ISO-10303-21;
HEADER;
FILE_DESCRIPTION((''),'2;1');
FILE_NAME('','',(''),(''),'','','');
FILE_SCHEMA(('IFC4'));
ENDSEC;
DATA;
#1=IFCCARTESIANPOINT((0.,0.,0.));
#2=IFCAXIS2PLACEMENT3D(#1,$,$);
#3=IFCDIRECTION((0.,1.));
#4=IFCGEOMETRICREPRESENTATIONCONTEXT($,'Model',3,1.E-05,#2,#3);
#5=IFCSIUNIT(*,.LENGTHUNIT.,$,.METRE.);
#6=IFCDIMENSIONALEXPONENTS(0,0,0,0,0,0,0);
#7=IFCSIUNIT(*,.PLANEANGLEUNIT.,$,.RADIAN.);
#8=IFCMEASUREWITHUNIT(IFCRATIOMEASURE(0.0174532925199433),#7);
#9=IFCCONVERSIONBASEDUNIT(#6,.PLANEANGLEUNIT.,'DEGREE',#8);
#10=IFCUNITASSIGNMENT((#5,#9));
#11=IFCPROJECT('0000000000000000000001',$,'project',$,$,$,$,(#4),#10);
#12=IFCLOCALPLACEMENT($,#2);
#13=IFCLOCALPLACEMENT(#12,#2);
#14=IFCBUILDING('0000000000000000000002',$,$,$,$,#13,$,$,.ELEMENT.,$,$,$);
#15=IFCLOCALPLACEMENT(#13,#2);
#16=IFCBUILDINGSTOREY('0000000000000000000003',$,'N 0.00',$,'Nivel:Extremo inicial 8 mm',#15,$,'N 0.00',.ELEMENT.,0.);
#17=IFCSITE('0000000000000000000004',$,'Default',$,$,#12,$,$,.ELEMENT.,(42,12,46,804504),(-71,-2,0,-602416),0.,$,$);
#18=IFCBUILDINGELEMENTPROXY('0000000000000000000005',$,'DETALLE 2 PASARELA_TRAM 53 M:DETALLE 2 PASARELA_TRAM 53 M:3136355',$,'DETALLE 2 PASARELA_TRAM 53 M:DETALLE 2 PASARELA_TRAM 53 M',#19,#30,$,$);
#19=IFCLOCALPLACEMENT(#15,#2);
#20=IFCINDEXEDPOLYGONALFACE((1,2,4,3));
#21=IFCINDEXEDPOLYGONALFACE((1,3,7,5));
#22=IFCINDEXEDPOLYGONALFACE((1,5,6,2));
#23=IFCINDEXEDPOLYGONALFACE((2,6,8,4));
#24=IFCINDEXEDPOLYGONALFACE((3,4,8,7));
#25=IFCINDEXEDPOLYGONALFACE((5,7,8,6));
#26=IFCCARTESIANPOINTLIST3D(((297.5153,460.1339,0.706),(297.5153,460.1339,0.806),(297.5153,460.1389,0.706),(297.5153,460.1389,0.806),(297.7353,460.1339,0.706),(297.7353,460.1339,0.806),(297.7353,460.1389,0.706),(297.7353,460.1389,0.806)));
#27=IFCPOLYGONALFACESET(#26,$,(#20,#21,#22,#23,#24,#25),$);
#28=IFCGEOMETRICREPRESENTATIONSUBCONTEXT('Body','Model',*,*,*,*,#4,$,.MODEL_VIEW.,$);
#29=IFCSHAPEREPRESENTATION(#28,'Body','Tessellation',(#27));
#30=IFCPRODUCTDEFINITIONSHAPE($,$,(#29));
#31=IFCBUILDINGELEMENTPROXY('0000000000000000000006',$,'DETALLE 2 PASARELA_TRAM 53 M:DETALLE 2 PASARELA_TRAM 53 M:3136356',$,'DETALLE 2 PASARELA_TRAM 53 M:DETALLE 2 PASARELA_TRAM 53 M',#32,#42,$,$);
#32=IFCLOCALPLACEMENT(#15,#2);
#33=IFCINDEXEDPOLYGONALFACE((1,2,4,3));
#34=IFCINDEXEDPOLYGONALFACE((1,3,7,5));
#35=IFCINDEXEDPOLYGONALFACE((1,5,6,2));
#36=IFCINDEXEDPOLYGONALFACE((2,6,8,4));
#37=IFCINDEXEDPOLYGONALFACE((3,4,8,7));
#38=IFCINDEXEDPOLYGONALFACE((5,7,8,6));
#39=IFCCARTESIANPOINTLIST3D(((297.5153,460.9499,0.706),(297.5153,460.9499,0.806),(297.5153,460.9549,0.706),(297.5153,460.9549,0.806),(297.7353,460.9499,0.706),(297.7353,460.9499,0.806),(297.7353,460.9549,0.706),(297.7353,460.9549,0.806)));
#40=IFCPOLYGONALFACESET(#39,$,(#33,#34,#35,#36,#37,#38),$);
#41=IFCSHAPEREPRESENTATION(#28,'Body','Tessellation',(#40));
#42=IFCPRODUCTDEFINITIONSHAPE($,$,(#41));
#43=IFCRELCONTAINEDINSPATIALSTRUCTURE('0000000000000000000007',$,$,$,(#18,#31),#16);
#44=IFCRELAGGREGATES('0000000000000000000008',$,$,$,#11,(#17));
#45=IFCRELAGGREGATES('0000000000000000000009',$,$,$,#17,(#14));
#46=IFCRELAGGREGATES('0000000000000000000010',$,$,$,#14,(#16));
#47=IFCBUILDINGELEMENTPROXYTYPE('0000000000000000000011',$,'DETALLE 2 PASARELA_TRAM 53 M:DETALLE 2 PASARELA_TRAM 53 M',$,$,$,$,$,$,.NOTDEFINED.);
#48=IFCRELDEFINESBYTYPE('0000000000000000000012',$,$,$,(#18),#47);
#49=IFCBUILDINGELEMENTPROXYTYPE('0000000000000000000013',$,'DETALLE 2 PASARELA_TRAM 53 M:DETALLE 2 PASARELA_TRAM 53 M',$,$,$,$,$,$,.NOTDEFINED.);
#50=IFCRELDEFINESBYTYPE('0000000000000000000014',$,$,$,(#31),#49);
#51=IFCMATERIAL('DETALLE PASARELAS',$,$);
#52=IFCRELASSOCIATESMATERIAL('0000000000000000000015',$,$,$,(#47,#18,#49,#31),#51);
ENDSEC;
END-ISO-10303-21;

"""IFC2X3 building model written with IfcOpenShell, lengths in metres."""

from ifc_helpers import new_model, entity, si_unit, converted_unit, direction, frame, frame_2d, origin, place, context, subcontext, project, spatial, rectangle, extrude, source, transform, mapped, material, type_object, type_shapes, element, save


model = new_model("IFC2X3")

# Units and contexts
model_context = context("Model", 3, precision=1e-05, world=origin(), true_north=direction((0.0, 1.0)))
body_context = subcontext(model_context, "Body", "Model", "MODEL_VIEW")
ifc_project = project(units=[si_unit("LENGTHUNIT", "METRE"), converted_unit("PLANEANGLEUNIT", "DEGREE", entity("IfcRatioMeasure", 0.0174532925199433), si_unit("PLANEANGLEUNIT", "RADIAN"), dimensions=[0, 0, 0, 0, 0, 0, 0])], contexts=[model_context])

# Site, building, storey
site_placement = place(None, origin())
site = spatial("IfcSite", under=ifc_project, at=site_placement, Name="Default", CompositionType="ELEMENT", RefLatitude=(42, 12, 46, 804504), RefLongitude=(-71, -2, 0, -602416), RefElevation=0.0)
building_placement = place(site_placement, origin())
building = spatial("IfcBuilding", under=site, at=building_placement, CompositionType="ELEMENT")
storey_placement = place(building_placement, origin())
storey = spatial("IfcBuildingStorey", under=building, at=storey_placement, Name="N 0.00", ObjectType="Nivel:Extremo inicial 8 mm", LongName="N 0.00", CompositionType="ELEMENT", Elevation=0.0)

# Building element proxies
ifc_material_1 = material(Name="DETALLE PASARELAS")
building_element_proxy_type_1 = type_object("IfcBuildingElementProxyType", Name="DETALLE 2 PASARELA_TRAM 53 M:DETALLE 2 PASARELA_TRAM 53 M", PredefinedType="NOTDEFINED", material=ifc_material_1)
shared_shape_1 = source(origin(), body_context, "Body", "SweptSolid", [
    extrude(rectangle(XDim=0.22, YDim=0.005, at=frame_2d((0.0, 0.0), x_axis=(1.0, 0.0))), frame((0.11, 0.0475, 0.0), z_axis=(0.0, 0.0, 1.0), x_axis=(-1.0, 0.0, 0.0)), (0.0, 0.0, 1.0), 0.1),
])
type_shapes(building_element_proxy_type_1, [shared_shape_1])
proxy_1_placement = place(storey_placement, frame((297.5153, 460.0889, 0.706)))
element("IfcBuildingElementProxy", 1, at=proxy_1_placement, inside=storey, type_object=building_element_proxy_type_1, material=ifc_material_1, Name="DETALLE 2 PASARELA_TRAM 53 M:DETALLE 2 PASARELA_TRAM 53 M:3136355", ObjectType="DETALLE 2 PASARELA_TRAM 53 M:DETALLE 2 PASARELA_TRAM 53 M", context=body_context, shape_type="MappedRepresentation", body=[
    mapped(shared_shape_1, transform((0.0, 0.0, 0.0), scale=1.0)),
])
building_element_proxy_type_2 = type_object("IfcBuildingElementProxyType", Name="DETALLE 2 PASARELA_TRAM 53 M:DETALLE 2 PASARELA_TRAM 53 M", PredefinedType="NOTDEFINED", material=ifc_material_1)
shared_shape_2 = source(origin(), body_context, "Body", "SweptSolid", [
    extrude(rectangle(XDim=0.005, YDim=0.22, at=frame_2d((0.0, 0.0), x_axis=(1.0, 0.0))), frame((0.11, -0.0475, 0.0), z_axis=(0.0, 0.0, 1.0), x_axis=(0.0, 1.0, 0.0)), (0.0, 0.0, 1.0), 0.1),
])
type_shapes(building_element_proxy_type_2, [shared_shape_2])
proxy_2_placement = place(storey_placement, frame((297.5153, 460.9999, 0.706)))
element("IfcBuildingElementProxy", 2, at=proxy_2_placement, inside=storey, type_object=building_element_proxy_type_2, material=ifc_material_1, Name="DETALLE 2 PASARELA_TRAM 53 M:DETALLE 2 PASARELA_TRAM 53 M:3136356", ObjectType="DETALLE 2 PASARELA_TRAM 53 M:DETALLE 2 PASARELA_TRAM 53 M", context=body_context, shape_type="MappedRepresentation", body=[
    mapped(shared_shape_2, transform((0.0, 0.0, 0.0), scale=1.0)),
])

save(model, "model.ifc")
